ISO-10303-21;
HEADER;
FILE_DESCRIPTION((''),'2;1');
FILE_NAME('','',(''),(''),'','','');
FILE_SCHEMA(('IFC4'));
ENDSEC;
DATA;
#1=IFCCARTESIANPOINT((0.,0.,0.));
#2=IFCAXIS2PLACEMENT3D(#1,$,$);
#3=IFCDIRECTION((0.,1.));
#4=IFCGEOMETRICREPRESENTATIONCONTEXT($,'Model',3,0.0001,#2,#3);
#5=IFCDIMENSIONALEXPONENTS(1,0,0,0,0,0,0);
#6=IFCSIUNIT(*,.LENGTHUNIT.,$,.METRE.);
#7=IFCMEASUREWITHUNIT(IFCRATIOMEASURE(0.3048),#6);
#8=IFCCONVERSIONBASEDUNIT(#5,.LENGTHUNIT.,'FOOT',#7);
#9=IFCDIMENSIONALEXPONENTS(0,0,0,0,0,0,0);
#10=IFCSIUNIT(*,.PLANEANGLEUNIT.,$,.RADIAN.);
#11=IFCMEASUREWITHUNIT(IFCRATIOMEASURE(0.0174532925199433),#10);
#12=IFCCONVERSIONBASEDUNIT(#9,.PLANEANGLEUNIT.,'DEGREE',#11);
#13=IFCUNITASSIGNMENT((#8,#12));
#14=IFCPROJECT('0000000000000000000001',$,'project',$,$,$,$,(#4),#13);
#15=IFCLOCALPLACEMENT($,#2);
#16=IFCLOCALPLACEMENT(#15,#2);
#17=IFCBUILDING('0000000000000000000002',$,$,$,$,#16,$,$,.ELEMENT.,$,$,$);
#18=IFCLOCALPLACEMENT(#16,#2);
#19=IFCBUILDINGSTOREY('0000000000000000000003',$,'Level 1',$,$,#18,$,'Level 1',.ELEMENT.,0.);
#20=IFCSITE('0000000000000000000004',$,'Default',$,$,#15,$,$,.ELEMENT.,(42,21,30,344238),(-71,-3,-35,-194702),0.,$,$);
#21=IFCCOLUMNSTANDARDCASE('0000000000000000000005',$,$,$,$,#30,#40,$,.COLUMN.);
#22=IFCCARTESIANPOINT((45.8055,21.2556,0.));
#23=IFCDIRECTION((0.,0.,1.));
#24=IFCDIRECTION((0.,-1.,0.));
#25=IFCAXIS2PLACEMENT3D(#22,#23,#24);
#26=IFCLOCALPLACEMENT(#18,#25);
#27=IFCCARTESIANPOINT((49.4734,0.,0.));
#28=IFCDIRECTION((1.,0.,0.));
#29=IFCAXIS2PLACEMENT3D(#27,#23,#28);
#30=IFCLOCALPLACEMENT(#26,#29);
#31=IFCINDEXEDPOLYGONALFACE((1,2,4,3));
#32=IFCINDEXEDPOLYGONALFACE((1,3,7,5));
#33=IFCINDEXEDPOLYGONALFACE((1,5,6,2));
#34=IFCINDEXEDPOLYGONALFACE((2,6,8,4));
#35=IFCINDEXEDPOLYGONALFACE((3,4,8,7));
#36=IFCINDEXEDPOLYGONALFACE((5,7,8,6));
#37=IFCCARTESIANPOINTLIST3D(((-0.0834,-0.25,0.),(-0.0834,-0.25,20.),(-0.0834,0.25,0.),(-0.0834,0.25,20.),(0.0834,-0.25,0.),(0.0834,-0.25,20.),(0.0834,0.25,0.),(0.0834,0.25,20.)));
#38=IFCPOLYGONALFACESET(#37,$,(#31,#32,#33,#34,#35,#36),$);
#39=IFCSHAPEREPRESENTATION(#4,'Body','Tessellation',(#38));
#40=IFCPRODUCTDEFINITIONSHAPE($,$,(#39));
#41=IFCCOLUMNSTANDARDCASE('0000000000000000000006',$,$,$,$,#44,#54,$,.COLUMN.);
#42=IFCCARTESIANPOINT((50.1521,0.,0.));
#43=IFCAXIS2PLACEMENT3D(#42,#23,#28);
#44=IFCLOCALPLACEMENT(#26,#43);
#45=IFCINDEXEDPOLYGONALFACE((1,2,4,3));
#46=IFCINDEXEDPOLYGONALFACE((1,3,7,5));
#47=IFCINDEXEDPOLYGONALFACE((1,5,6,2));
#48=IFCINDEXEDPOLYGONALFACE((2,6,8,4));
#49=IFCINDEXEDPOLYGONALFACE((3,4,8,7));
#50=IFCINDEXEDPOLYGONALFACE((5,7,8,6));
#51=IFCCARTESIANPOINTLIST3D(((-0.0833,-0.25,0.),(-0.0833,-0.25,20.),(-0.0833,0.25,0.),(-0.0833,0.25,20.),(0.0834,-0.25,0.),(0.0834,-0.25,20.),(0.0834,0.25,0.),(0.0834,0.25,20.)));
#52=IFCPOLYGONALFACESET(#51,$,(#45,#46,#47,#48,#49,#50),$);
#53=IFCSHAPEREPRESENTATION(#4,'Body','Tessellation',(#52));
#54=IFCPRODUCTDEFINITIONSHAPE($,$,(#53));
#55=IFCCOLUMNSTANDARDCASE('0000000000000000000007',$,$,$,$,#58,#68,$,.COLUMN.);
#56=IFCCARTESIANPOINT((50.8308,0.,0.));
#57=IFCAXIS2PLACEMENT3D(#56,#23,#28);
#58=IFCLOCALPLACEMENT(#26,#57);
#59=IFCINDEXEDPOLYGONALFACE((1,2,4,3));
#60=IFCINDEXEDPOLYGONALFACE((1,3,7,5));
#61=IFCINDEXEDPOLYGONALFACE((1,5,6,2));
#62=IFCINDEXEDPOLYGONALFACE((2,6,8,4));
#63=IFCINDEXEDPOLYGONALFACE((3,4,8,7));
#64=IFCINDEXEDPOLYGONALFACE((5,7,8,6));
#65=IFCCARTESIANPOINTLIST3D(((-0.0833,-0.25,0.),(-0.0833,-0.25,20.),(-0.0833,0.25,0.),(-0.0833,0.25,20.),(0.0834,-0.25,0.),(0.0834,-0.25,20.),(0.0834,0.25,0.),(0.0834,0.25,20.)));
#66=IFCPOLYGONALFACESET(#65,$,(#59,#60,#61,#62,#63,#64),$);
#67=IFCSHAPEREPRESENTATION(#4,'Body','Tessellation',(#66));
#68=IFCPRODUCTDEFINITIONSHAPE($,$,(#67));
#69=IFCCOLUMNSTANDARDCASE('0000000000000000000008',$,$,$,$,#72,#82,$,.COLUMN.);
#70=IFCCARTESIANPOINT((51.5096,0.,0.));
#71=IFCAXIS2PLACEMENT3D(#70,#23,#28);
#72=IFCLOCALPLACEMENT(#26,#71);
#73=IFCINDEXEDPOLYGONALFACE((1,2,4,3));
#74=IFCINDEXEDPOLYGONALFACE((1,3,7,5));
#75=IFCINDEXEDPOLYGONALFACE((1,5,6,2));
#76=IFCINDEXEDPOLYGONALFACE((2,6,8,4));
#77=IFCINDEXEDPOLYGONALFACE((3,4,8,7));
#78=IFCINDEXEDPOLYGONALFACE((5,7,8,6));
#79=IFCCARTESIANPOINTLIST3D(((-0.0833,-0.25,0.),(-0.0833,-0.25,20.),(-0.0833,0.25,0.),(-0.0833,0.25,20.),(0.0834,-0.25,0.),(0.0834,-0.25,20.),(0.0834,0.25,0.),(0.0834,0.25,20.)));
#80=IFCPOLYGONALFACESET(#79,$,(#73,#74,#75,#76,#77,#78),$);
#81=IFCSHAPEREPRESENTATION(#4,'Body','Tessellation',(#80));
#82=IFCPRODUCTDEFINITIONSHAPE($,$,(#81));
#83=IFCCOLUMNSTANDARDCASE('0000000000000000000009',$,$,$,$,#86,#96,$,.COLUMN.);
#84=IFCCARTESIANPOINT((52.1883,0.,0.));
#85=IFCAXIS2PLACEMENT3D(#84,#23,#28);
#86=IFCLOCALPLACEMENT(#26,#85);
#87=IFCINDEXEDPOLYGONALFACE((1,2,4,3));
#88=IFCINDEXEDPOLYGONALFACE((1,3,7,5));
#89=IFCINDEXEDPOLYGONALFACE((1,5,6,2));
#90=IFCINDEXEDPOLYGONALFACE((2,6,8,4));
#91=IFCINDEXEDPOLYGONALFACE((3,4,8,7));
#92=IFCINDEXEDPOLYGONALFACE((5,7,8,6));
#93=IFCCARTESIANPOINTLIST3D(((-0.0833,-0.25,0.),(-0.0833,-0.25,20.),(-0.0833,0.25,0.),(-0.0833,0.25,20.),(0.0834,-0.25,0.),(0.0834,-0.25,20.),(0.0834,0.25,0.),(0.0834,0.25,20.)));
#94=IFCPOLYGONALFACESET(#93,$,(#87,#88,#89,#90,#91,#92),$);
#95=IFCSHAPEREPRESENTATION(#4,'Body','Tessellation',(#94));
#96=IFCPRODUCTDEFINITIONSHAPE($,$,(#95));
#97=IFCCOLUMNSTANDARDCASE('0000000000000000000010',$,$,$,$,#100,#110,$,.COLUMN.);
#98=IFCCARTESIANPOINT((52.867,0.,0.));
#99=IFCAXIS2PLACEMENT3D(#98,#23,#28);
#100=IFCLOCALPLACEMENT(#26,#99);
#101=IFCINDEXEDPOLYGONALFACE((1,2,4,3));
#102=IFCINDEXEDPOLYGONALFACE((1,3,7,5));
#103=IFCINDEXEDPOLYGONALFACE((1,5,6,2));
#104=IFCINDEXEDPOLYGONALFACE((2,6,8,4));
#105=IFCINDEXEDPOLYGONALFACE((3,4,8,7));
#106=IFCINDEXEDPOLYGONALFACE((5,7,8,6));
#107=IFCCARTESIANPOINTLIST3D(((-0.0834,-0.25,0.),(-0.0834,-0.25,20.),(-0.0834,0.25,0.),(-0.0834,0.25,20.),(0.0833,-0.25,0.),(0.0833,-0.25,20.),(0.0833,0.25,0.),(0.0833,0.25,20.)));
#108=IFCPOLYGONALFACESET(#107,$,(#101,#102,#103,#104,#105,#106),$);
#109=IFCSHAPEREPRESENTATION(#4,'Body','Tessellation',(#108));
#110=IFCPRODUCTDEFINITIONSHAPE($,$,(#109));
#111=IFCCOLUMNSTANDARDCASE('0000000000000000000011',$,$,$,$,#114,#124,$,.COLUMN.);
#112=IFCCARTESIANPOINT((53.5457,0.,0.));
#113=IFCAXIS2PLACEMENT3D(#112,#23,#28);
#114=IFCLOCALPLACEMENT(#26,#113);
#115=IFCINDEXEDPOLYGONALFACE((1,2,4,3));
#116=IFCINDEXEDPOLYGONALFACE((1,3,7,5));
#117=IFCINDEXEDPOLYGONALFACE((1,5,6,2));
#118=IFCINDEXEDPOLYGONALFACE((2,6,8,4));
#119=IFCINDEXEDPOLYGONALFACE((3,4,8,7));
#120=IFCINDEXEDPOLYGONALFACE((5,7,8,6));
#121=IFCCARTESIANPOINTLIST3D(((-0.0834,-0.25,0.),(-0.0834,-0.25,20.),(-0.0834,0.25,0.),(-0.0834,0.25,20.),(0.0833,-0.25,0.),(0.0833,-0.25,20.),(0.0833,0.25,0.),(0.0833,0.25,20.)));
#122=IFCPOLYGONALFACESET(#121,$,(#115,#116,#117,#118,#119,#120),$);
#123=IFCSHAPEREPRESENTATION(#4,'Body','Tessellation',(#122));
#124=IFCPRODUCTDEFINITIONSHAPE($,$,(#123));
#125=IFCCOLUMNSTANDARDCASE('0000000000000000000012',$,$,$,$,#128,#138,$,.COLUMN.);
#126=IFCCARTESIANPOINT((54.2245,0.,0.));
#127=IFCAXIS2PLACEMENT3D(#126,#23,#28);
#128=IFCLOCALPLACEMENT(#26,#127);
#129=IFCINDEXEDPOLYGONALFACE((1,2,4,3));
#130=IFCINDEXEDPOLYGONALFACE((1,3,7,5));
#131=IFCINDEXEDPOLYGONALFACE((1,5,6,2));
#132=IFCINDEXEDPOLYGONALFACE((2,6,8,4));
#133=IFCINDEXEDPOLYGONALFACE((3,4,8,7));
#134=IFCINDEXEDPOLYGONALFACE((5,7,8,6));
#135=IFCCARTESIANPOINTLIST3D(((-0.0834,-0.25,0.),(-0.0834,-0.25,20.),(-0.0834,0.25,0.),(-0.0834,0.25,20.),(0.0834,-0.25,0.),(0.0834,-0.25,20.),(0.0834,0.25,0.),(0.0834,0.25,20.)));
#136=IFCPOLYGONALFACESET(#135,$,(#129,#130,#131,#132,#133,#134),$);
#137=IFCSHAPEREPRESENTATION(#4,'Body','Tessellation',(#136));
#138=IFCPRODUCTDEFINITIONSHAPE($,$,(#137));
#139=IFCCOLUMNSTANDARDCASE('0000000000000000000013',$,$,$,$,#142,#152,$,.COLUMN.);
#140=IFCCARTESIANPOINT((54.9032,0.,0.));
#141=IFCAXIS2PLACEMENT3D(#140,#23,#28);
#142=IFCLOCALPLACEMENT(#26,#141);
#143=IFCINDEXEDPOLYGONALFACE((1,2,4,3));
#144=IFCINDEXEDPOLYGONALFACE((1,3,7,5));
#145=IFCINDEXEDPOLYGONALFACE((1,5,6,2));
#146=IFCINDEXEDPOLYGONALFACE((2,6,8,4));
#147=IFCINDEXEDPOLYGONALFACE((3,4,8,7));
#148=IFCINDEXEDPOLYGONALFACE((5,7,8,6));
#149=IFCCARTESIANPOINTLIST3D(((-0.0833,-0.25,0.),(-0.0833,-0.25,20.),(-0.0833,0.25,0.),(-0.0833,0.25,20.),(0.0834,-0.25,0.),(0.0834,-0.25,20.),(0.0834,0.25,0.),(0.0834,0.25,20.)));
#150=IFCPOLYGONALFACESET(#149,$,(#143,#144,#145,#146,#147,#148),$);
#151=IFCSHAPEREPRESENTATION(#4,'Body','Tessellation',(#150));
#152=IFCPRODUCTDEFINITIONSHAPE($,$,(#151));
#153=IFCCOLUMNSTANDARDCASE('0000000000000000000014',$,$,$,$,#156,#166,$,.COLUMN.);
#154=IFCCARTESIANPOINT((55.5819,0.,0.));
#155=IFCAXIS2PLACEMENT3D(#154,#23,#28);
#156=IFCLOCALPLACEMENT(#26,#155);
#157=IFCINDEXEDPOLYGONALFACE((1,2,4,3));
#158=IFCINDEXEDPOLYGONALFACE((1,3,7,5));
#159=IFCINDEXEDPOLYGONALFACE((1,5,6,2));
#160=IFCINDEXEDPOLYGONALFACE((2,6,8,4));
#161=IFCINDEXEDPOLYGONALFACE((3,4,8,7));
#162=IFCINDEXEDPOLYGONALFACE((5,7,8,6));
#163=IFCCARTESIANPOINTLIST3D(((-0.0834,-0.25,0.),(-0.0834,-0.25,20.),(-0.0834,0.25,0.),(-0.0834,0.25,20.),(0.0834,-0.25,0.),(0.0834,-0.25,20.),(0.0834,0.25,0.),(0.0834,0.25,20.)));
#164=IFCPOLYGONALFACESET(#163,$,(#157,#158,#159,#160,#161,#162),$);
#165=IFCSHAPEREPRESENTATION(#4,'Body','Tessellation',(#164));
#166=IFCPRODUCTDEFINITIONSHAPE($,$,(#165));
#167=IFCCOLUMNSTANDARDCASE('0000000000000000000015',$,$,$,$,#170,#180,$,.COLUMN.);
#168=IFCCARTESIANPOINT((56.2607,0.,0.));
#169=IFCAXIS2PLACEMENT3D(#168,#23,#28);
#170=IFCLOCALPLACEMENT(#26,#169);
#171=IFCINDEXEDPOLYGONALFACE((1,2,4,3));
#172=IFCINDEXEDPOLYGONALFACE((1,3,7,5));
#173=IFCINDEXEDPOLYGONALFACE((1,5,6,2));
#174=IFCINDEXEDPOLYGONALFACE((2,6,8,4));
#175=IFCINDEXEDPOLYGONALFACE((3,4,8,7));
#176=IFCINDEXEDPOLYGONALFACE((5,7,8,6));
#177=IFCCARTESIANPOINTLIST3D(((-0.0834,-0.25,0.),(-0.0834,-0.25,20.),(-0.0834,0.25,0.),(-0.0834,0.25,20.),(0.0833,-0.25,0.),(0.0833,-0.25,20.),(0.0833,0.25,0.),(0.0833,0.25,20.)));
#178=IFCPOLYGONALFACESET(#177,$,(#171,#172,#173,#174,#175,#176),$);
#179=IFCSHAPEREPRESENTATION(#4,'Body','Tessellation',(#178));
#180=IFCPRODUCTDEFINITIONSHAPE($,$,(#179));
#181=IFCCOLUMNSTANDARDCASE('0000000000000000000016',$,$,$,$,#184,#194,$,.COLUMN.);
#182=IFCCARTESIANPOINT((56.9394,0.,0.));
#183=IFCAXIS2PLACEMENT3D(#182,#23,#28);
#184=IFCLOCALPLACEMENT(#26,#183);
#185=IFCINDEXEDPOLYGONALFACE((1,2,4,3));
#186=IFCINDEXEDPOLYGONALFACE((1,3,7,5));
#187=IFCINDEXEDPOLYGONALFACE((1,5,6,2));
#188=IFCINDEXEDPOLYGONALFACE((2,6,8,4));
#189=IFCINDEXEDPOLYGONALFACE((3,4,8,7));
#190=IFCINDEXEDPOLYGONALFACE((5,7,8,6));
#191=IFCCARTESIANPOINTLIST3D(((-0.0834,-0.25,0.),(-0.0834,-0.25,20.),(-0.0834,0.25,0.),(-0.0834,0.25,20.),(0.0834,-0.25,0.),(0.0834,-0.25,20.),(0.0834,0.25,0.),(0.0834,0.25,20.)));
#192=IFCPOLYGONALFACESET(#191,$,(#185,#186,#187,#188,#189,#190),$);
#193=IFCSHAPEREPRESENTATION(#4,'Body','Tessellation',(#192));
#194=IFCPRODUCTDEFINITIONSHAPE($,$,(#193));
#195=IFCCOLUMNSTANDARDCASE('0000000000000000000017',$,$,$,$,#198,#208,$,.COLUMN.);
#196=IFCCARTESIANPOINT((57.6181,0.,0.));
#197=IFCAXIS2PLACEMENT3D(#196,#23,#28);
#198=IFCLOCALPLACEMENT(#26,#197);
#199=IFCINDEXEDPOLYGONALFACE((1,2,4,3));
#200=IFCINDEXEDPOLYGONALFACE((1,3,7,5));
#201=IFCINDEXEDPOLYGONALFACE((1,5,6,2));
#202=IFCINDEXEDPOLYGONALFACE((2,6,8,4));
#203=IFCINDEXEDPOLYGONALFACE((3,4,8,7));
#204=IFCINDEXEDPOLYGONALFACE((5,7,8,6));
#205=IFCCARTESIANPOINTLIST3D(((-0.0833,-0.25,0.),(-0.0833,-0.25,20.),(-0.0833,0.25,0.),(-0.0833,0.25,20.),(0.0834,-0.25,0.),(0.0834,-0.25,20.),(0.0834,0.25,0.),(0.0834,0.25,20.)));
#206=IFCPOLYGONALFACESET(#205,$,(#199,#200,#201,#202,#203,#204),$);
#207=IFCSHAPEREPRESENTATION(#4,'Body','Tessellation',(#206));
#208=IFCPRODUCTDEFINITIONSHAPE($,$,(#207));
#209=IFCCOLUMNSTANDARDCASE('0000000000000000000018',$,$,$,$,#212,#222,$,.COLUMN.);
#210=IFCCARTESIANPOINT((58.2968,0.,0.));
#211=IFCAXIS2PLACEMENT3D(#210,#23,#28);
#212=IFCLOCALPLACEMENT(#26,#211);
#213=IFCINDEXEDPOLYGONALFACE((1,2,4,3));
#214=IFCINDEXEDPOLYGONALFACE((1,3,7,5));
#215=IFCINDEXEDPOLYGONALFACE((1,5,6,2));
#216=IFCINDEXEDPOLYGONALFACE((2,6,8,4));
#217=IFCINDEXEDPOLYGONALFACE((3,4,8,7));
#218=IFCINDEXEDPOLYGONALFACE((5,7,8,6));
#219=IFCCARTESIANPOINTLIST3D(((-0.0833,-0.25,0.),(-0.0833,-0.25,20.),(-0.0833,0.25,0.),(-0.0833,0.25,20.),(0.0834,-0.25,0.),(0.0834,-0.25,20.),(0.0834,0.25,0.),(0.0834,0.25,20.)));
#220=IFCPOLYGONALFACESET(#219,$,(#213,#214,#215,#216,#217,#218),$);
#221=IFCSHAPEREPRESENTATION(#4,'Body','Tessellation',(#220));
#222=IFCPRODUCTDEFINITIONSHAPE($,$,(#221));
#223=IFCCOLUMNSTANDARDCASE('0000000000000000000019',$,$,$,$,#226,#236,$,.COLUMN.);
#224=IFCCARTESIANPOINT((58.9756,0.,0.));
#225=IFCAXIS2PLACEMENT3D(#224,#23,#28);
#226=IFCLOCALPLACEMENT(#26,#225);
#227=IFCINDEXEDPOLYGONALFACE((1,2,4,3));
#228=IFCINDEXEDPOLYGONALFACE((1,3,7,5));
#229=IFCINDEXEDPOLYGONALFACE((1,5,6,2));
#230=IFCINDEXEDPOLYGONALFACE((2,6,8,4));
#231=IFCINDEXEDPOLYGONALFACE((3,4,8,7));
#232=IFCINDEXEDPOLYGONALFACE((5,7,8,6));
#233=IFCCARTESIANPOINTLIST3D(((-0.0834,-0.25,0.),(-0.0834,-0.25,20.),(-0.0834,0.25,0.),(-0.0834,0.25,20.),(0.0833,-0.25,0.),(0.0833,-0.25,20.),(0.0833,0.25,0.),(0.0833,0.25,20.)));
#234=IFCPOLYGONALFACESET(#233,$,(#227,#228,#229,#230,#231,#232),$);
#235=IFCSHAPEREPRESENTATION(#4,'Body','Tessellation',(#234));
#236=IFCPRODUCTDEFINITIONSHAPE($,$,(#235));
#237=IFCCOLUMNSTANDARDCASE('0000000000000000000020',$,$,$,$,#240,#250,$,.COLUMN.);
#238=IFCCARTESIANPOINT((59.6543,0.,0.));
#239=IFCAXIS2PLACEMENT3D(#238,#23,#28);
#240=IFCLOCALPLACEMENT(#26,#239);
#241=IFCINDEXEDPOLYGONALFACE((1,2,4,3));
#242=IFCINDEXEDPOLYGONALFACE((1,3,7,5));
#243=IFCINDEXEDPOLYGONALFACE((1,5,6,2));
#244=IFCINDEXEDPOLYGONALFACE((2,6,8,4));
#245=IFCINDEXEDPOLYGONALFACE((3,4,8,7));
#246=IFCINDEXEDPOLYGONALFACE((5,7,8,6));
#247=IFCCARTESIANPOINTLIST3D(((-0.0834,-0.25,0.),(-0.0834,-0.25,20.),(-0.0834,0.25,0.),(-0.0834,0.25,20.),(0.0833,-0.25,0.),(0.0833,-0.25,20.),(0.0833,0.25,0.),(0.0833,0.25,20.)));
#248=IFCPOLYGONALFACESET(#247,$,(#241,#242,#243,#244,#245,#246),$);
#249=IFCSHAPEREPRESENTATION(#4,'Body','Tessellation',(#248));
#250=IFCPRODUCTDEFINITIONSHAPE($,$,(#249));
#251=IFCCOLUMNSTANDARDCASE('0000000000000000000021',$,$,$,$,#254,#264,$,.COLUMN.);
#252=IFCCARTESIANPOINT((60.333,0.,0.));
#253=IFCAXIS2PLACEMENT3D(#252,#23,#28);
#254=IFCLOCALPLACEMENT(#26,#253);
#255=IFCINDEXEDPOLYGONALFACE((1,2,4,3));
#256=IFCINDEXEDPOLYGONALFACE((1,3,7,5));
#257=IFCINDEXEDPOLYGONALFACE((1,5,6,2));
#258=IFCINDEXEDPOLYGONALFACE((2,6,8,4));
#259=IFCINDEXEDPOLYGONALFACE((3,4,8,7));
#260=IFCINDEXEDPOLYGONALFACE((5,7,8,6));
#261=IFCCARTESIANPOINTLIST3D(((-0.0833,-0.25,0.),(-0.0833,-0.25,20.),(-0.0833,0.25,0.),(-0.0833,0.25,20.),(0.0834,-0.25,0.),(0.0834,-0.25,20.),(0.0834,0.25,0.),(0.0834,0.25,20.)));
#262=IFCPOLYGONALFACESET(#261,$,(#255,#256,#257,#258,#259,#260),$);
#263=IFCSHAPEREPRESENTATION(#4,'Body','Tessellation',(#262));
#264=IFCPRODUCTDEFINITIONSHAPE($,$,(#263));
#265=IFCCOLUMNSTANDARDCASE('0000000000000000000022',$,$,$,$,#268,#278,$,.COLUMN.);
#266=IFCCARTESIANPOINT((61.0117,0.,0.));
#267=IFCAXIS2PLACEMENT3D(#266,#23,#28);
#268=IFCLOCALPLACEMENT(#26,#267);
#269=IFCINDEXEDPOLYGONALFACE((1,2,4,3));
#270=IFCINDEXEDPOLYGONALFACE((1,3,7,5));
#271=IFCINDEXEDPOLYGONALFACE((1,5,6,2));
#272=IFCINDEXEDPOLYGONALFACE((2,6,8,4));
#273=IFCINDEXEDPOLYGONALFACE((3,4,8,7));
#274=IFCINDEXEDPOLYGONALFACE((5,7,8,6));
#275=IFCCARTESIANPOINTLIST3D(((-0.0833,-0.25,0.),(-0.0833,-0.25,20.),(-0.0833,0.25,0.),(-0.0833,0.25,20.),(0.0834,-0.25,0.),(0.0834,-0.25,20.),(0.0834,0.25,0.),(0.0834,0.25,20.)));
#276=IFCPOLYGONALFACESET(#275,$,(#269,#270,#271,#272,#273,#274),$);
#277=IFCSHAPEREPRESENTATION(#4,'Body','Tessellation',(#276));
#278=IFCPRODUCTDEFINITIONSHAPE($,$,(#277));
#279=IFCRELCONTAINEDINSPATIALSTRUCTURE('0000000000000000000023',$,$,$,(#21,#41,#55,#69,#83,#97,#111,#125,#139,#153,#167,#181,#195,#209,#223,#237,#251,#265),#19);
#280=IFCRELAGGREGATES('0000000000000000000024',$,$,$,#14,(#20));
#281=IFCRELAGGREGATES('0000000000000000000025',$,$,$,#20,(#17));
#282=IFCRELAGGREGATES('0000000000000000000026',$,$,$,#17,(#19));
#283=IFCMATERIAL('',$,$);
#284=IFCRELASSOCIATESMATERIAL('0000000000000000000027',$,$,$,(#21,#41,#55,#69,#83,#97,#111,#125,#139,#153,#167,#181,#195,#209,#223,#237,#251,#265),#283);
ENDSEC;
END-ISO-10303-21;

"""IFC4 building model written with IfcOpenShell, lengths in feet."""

from ifc_helpers import new_model, entity, si_unit, converted_unit, direction, frame, origin, place, context, project, spatial, rectangle, extrude, material, element, save


model = new_model("IFC4")

# Units and contexts
model_context = context("Model", 3, precision=0.0001, world=origin(), true_north=direction((0.0, 1.0)))
ifc_project = project(units=[converted_unit("LENGTHUNIT", "FOOT", entity("IfcRatioMeasure", 0.3048), si_unit("LENGTHUNIT", "METRE"), dimensions=[1, 0, 0, 0, 0, 0, 0]), converted_unit("PLANEANGLEUNIT", "DEGREE", entity("IfcRatioMeasure", 0.0174532925199433), si_unit("PLANEANGLEUNIT", "RADIAN"), dimensions=[0, 0, 0, 0, 0, 0, 0])], contexts=[model_context])

# Site, building, storey
site_placement = place(None, origin())
site = spatial("IfcSite", under=ifc_project, at=site_placement, Name="Default", CompositionType="ELEMENT", RefLatitude=(42, 21, 30, 344238), RefLongitude=(-71, -3, -35, -194702), RefElevation=0.0)
building_placement = place(site_placement, origin())
building = spatial("IfcBuilding", under=site, at=building_placement, CompositionType="ELEMENT")
storey_placement = place(building_placement, origin())
storey = spatial("IfcBuildingStorey", under=building, at=storey_placement, Name="Level 1", LongName="Level 1", CompositionType="ELEMENT", Elevation=0.0)

# Columns
ifc_material_1 = material(Name="")
placement = place(storey_placement, frame((45.8055, 21.2556, 0.0), z_axis=(0.0, 0.0, 1.0), x_axis=(0.0, -1.0, 0.0)))
for number, where, z_axis, x_axis in (
    (1, (49.4734, 0.0, 0.0), (0.0, 0.0, 1.0), (1.0, 0.0, 0.0)),
    (2, (50.1521, 0.0, 0.0), (0.0, 0.0, 1.0), (1.0, 0.0, 0.0)),
    (3, (50.8308, 0.0, 0.0), (0.0, 0.0, 1.0), (1.0, 0.0, 0.0)),
    (4, (51.5096, 0.0, 0.0), (0.0, 0.0, 1.0), (1.0, 0.0, 0.0)),
    (5, (52.1883, 0.0, 0.0), (0.0, 0.0, 1.0), (1.0, 0.0, 0.0)),
    (6, (52.867, 0.0, 0.0), (0.0, 0.0, 1.0), (1.0, 0.0, 0.0)),
    (7, (53.5457, 0.0, 0.0), (0.0, 0.0, 1.0), (1.0, 0.0, 0.0)),
    (8, (54.2245, 0.0, 0.0), (0.0, 0.0, 1.0), (1.0, 0.0, 0.0)),
    (9, (54.9032, 0.0, 0.0), (0.0, 0.0, 1.0), (1.0, 0.0, 0.0)),
    (10, (55.5819, 0.0, 0.0), (0.0, 0.0, 1.0), (1.0, 0.0, 0.0)),
    (11, (56.2607, 0.0, 0.0), (0.0, 0.0, 1.0), (1.0, 0.0, 0.0)),
    (12, (56.9394, 0.0, 0.0), (0.0, 0.0, 1.0), (1.0, 0.0, 0.0)),
    (13, (57.6181, 0.0, 0.0), (0.0, 0.0, 1.0), (1.0, 0.0, 0.0)),
    (14, (58.2968, 0.0, 0.0), (0.0, 0.0, 1.0), (1.0, 0.0, 0.0)),
    (15, (58.9756, 0.0, 0.0), (0.0, 0.0, 1.0), (1.0, 0.0, 0.0)),
    (16, (59.6543, 0.0, 0.0), (0.0, 0.0, 1.0), (1.0, 0.0, 0.0)),
    (17, (60.333, 0.0, 0.0), (0.0, 0.0, 1.0), (1.0, 0.0, 0.0)),
    (18, (61.0117, 0.0, 0.0), (0.0, 0.0, 1.0), (1.0, 0.0, 0.0)),
):
    element("IfcColumnStandardCase", number, at=place(placement, frame(where, z_axis=z_axis, x_axis=x_axis)), inside=storey, material=ifc_material_1, PredefinedType="COLUMN", context=model_context, shape_type="SweptSolid", body=[
        extrude(rectangle(XDim=0.1667, YDim=0.5), origin(), (0.0, 0.0, 1.0), 20.0),
    ])

save(model, "model.ifc")
